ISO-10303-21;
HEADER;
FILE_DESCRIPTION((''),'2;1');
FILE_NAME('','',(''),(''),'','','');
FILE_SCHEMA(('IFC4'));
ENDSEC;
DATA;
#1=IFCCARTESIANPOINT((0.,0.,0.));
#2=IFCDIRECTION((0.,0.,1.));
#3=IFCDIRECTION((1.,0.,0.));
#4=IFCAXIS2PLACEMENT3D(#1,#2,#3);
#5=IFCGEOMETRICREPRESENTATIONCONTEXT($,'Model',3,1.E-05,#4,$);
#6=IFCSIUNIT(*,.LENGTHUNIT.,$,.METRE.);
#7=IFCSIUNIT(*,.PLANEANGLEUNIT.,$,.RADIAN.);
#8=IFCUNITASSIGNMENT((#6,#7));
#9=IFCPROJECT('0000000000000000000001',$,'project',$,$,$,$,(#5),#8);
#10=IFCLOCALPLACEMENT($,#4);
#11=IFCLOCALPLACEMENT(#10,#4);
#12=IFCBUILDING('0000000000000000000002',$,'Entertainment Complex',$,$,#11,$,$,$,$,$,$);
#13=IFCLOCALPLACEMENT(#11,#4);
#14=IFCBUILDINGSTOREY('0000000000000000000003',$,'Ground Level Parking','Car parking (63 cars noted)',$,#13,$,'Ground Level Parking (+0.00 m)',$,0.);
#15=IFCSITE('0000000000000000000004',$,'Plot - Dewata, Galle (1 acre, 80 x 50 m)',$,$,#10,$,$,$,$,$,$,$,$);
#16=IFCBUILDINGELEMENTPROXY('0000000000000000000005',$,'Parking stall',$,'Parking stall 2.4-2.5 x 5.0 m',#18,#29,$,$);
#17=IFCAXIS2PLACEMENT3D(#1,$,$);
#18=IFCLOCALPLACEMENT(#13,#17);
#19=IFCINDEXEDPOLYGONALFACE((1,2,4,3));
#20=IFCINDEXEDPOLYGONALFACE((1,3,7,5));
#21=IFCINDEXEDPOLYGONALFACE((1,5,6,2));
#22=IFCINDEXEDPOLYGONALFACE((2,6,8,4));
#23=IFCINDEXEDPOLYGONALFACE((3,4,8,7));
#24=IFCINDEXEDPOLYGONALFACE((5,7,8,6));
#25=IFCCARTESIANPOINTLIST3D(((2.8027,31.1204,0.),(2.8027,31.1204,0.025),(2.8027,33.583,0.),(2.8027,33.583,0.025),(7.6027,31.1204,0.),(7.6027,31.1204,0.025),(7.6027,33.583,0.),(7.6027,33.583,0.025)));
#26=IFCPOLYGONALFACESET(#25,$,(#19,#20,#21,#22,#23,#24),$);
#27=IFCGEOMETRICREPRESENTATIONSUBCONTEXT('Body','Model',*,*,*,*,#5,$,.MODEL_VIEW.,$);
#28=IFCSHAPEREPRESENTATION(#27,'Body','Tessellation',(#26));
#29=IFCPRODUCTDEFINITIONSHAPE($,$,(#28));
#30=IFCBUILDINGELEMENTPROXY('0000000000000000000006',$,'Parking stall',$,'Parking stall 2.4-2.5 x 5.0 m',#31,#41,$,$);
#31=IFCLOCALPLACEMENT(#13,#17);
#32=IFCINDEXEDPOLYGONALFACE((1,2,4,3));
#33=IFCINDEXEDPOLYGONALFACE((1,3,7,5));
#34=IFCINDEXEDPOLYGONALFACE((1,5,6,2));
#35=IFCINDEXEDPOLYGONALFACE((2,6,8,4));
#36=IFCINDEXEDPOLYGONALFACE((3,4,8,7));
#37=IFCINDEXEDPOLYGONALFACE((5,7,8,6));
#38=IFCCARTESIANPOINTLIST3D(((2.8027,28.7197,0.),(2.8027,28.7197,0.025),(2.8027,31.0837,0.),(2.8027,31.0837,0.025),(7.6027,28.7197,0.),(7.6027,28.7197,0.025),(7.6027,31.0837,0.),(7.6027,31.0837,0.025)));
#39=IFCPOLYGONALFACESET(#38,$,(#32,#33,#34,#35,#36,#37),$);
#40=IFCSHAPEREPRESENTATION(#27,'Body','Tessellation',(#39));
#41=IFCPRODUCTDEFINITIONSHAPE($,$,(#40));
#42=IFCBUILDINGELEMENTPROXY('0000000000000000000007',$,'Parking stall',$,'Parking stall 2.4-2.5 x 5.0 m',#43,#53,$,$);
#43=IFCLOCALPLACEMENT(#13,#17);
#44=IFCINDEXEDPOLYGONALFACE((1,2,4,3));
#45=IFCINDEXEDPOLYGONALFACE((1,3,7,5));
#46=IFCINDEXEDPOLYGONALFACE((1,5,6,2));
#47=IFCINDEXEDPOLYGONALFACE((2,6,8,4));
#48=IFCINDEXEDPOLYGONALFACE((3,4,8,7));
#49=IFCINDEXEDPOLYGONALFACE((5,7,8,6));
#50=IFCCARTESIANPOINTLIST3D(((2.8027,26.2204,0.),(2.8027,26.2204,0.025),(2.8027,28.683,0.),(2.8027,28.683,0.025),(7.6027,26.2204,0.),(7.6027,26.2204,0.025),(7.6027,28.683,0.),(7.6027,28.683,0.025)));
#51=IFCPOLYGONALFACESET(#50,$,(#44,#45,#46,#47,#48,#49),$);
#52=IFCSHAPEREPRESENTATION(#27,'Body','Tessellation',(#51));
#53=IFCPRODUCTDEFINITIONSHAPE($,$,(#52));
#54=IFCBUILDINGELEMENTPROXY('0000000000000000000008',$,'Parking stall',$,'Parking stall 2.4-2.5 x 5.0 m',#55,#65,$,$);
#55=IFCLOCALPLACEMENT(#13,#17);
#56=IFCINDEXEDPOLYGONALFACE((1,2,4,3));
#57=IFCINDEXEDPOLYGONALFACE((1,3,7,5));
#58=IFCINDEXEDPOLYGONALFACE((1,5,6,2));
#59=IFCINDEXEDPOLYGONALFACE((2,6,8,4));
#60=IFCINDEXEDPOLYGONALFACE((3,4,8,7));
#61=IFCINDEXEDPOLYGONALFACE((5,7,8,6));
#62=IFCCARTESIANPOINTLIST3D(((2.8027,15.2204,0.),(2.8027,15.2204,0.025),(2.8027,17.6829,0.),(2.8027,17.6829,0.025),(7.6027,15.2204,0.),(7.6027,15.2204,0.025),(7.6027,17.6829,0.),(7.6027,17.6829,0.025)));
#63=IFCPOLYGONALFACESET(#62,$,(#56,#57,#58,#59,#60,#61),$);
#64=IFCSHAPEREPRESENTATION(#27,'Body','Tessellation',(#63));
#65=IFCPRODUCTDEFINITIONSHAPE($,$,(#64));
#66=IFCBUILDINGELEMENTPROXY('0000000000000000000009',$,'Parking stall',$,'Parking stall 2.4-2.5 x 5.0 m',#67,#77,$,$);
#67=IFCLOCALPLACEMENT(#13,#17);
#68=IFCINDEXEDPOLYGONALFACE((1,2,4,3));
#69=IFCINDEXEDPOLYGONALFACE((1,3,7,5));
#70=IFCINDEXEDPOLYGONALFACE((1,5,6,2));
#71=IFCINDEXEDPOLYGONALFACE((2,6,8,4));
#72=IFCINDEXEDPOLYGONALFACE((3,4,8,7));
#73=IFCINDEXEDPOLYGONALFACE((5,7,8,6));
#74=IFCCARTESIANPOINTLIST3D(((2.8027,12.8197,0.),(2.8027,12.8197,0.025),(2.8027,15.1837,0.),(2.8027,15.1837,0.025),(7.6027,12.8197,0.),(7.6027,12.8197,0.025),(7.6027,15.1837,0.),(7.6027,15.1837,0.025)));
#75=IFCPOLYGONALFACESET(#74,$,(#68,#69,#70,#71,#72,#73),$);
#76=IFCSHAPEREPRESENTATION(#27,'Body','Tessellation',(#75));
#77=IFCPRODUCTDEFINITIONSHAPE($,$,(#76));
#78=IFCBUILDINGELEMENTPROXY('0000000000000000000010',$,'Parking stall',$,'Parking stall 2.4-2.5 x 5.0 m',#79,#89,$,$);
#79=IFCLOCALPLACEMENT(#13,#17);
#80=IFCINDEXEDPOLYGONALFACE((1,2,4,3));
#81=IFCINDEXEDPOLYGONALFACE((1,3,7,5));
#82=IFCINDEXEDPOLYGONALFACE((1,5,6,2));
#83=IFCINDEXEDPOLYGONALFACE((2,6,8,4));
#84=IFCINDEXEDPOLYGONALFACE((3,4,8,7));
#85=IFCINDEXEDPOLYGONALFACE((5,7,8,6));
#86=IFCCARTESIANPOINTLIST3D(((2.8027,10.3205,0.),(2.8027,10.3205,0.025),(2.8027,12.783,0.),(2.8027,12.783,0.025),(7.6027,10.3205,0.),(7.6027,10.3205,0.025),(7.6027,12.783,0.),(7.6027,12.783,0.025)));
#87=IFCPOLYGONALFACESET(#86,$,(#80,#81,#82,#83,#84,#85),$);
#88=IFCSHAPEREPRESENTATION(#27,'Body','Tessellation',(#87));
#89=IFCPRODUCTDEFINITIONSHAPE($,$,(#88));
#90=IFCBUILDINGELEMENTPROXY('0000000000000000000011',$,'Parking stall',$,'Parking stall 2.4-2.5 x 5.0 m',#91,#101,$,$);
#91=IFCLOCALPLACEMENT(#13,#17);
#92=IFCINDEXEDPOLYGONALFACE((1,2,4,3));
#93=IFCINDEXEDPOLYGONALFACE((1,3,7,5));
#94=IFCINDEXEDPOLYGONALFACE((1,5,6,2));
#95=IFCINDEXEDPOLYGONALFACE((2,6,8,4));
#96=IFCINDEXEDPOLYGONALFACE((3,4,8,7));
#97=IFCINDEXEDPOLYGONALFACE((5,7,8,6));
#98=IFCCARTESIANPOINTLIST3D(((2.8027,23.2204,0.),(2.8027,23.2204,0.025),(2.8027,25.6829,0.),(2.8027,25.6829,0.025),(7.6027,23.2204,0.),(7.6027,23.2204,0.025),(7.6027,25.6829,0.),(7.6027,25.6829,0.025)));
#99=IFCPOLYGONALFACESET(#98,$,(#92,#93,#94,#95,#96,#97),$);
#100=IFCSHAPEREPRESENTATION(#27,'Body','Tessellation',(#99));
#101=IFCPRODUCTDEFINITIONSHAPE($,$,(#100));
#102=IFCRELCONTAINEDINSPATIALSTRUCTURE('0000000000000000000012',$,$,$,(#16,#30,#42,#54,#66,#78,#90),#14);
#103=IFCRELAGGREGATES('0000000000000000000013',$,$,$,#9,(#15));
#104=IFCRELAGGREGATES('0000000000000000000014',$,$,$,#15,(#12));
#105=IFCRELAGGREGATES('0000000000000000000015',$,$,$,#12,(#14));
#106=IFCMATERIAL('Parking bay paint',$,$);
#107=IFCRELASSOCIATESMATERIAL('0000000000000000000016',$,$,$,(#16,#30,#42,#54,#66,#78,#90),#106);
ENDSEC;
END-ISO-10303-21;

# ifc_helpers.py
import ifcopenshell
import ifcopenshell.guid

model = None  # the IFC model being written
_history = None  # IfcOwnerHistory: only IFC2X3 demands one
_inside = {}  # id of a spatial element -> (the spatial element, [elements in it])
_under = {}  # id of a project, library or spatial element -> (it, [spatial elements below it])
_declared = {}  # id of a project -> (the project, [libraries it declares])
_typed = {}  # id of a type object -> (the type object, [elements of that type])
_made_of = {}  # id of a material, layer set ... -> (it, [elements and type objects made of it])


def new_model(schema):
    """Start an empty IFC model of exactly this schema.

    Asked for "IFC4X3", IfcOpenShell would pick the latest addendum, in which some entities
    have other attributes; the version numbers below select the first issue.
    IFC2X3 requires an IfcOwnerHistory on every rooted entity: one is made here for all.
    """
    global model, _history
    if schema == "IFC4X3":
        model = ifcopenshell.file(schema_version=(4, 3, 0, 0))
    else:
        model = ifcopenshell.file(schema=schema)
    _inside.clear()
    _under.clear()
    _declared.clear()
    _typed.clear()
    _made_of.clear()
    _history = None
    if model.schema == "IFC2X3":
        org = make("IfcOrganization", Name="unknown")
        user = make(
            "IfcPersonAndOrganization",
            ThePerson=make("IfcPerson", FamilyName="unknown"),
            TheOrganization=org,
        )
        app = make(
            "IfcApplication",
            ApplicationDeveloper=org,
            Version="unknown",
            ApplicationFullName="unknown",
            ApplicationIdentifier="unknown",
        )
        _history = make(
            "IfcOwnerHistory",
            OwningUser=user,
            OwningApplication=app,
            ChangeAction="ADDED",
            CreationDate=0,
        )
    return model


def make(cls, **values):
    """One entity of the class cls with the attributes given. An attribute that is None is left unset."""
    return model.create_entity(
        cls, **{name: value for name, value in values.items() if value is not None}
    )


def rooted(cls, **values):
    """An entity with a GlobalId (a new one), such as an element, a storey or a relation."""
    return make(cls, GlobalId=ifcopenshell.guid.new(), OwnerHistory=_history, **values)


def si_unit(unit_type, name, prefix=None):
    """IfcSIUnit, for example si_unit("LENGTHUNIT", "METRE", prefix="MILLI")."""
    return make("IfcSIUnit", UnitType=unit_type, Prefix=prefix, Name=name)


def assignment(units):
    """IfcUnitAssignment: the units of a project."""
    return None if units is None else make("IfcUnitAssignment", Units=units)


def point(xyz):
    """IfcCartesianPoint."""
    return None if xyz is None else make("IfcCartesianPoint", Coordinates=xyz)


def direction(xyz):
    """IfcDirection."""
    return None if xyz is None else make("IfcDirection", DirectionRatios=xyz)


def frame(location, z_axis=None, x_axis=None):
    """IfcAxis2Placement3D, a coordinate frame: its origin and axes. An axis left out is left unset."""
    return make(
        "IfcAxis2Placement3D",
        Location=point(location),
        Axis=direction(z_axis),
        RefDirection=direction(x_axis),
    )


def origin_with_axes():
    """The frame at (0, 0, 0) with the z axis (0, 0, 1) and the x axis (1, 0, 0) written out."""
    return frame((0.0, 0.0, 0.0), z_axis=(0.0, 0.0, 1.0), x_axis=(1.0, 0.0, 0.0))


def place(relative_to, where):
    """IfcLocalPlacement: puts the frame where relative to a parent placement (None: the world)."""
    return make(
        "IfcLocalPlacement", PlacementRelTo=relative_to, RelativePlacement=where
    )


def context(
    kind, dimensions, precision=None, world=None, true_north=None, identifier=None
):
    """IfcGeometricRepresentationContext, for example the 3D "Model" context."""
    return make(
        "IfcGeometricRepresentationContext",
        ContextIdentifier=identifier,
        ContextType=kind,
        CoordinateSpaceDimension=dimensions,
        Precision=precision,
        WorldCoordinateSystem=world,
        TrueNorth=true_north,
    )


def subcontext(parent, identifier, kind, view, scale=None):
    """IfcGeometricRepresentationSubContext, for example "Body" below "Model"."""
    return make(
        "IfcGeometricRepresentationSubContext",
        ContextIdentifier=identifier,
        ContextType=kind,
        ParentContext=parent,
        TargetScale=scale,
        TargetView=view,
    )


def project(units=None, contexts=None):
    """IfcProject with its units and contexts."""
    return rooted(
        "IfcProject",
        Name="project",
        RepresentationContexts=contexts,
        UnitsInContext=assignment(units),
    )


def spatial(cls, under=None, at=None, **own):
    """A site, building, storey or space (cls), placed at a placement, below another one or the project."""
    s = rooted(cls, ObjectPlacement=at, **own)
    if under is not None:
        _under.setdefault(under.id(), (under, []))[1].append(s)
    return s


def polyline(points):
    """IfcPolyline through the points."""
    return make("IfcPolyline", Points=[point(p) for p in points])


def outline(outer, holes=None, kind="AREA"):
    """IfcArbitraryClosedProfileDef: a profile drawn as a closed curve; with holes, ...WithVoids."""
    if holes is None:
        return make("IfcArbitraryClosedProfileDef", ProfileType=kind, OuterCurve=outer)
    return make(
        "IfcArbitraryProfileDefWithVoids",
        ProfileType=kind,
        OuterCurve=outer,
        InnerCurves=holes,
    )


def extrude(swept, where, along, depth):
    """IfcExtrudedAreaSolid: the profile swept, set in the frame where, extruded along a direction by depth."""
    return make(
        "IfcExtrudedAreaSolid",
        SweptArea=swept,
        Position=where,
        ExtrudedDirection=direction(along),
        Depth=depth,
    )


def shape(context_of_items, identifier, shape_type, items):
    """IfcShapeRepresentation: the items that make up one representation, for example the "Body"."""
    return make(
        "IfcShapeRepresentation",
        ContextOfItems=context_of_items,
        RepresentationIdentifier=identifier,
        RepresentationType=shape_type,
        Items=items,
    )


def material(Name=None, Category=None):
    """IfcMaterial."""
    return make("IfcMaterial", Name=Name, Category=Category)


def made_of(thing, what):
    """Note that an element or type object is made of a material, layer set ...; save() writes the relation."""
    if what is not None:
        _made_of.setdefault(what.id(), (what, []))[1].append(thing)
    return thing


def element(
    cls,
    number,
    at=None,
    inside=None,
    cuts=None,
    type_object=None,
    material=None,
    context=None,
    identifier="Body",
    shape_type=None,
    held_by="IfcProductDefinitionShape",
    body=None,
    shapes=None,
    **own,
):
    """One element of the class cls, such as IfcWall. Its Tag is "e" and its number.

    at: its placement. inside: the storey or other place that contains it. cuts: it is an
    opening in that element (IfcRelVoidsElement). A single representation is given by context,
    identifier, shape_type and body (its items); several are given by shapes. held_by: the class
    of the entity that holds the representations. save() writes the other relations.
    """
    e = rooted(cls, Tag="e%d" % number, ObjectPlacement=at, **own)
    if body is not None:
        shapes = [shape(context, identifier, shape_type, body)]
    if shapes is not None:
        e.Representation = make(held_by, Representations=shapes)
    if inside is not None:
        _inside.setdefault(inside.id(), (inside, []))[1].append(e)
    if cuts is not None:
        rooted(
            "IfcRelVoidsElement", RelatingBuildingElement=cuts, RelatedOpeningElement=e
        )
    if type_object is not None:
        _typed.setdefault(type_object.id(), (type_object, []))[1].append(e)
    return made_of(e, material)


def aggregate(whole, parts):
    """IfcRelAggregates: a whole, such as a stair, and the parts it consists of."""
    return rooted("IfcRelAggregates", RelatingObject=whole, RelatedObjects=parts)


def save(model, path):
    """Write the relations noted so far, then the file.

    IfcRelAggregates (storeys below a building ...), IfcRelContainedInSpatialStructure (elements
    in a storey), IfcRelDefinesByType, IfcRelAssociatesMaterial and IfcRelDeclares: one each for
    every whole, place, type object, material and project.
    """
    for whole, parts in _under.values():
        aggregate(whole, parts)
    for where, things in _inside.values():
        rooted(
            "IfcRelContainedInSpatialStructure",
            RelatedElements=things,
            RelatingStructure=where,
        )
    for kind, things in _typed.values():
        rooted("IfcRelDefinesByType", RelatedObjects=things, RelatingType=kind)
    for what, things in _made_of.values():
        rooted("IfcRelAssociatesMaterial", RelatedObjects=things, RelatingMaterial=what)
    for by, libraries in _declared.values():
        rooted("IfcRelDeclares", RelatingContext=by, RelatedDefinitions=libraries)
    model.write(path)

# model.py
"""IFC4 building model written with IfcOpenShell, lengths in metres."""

from ifc_helpers import new_model, si_unit, origin_with_axes, place, context, subcontext, project, spatial, polyline, outline, extrude, material, element, save


model = new_model("IFC4")

# Units and contexts
model_context = context("Model", 3, precision=1e-05, world=origin_with_axes())
body_context = subcontext(model_context, "Body", "Model", "MODEL_VIEW")
ifc_project = project(units=[si_unit("LENGTHUNIT", "METRE"), si_unit("PLANEANGLEUNIT", "RADIAN")], contexts=[model_context])

# Site, building, storey
site_placement = place(None, origin_with_axes())
site = spatial("IfcSite", under=ifc_project, at=site_placement, Name="Plot - Dewata, Galle (1 acre, 80 x 50 m)")
building_placement = place(site_placement, origin_with_axes())
building = spatial("IfcBuilding", under=site, at=building_placement, Name="Entertainment Complex")
storey_placement = place(building_placement, origin_with_axes())
storey = spatial("IfcBuildingStorey", under=building, at=storey_placement, Name="Ground Level Parking", Description="Car parking (63 cars noted)", LongName="Ground Level Parking (+0.00 m)", Elevation=0.0)

# Building element proxies
ifc_material_1 = material(Name="Parking bay paint")
proxy_1_placement = place(storey_placement, origin_with_axes())
element("IfcBuildingElementProxy", 1, at=proxy_1_placement, inside=storey, material=ifc_material_1, Name="Parking stall", ObjectType="Parking stall 2.4-2.5 x 5.0 m", context=body_context, shape_type="SweptSolid", body=[
    extrude(outline(polyline([(2.8027, 33.583), (2.8027, 31.1205), (7.6027, 31.1205), (7.6027, 33.583), (2.8027, 33.583)])), origin_with_axes(), (0.0, 0.0, 1.0), 0.025),
])
proxy_2_placement = place(storey_placement, origin_with_axes())
element("IfcBuildingElementProxy", 2, at=proxy_2_placement, inside=storey, material=ifc_material_1, Name="Parking stall", ObjectType="Parking stall 2.4-2.5 x 5.0 m", context=body_context, shape_type="SweptSolid", body=[
    extrude(outline(polyline([(2.8027, 31.0837), (2.8027, 28.7197), (7.6027, 28.7197), (7.6027, 31.0837), (2.8027, 31.0837)])), origin_with_axes(), (0.0, 0.0, 1.0), 0.025),
])
proxy_3_placement = place(storey_placement, origin_with_axes())
element("IfcBuildingElementProxy", 3, at=proxy_3_placement, inside=storey, material=ifc_material_1, Name="Parking stall", ObjectType="Parking stall 2.4-2.5 x 5.0 m", context=body_context, shape_type="SweptSolid", body=[
    extrude(outline(polyline([(2.8027, 28.6829), (2.8027, 26.2204), (7.6027, 26.2204), (7.6027, 28.6829), (2.8027, 28.6829)])), origin_with_axes(), (0.0, 0.0, 1.0), 0.025),
])
proxy_4_placement = place(storey_placement, origin_with_axes())
element("IfcBuildingElementProxy", 4, at=proxy_4_placement, inside=storey, material=ifc_material_1, Name="Parking stall", ObjectType="Parking stall 2.4-2.5 x 5.0 m", context=body_context, shape_type="SweptSolid", body=[
    extrude(outline(polyline([(2.8027, 17.6829), (2.8027, 15.2205), (7.6027, 15.2205), (7.6027, 17.6829), (2.8027, 17.6829)])), origin_with_axes(), (0.0, 0.0, 1.0), 0.025),
])
proxy_5_placement = place(storey_placement, origin_with_axes())
element("IfcBuildingElementProxy", 5, at=proxy_5_placement, inside=storey, material=ifc_material_1, Name="Parking stall", ObjectType="Parking stall 2.4-2.5 x 5.0 m", context=body_context, shape_type="SweptSolid", body=[
    extrude(outline(polyline([(2.8027, 15.1837), (2.8027, 12.8197), (7.6027, 12.8197), (7.6027, 15.1837), (2.8027, 15.1837)])), origin_with_axes(), (0.0, 0.0, 1.0), 0.025),
])
proxy_6_placement = place(storey_placement, origin_with_axes())
element("IfcBuildingElementProxy", 6, at=proxy_6_placement, inside=storey, material=ifc_material_1, Name="Parking stall", ObjectType="Parking stall 2.4-2.5 x 5.0 m", context=body_context, shape_type="SweptSolid", body=[
    extrude(outline(polyline([(2.8027, 12.7829), (2.8027, 10.3205), (7.6027, 10.3205), (7.6027, 12.7829), (2.8027, 12.7829)])), origin_with_axes(), (0.0, 0.0, 1.0), 0.025),
])
proxy_7_placement = place(storey_placement, origin_with_axes())
element("IfcBuildingElementProxy", 7, at=proxy_7_placement, inside=storey, material=ifc_material_1, Name="Parking stall", ObjectType="Parking stall 2.4-2.5 x 5.0 m", context=body_context, shape_type="SweptSolid", body=[
    extrude(outline(polyline([(2.8027, 25.6829), (2.8027, 23.2204), (7.6027, 23.2204), (7.6027, 25.6829), (2.8027, 25.6829)])), origin_with_axes(), (0.0, 0.0, 1.0), 0.025),
])

save(model, "model.ifc")
